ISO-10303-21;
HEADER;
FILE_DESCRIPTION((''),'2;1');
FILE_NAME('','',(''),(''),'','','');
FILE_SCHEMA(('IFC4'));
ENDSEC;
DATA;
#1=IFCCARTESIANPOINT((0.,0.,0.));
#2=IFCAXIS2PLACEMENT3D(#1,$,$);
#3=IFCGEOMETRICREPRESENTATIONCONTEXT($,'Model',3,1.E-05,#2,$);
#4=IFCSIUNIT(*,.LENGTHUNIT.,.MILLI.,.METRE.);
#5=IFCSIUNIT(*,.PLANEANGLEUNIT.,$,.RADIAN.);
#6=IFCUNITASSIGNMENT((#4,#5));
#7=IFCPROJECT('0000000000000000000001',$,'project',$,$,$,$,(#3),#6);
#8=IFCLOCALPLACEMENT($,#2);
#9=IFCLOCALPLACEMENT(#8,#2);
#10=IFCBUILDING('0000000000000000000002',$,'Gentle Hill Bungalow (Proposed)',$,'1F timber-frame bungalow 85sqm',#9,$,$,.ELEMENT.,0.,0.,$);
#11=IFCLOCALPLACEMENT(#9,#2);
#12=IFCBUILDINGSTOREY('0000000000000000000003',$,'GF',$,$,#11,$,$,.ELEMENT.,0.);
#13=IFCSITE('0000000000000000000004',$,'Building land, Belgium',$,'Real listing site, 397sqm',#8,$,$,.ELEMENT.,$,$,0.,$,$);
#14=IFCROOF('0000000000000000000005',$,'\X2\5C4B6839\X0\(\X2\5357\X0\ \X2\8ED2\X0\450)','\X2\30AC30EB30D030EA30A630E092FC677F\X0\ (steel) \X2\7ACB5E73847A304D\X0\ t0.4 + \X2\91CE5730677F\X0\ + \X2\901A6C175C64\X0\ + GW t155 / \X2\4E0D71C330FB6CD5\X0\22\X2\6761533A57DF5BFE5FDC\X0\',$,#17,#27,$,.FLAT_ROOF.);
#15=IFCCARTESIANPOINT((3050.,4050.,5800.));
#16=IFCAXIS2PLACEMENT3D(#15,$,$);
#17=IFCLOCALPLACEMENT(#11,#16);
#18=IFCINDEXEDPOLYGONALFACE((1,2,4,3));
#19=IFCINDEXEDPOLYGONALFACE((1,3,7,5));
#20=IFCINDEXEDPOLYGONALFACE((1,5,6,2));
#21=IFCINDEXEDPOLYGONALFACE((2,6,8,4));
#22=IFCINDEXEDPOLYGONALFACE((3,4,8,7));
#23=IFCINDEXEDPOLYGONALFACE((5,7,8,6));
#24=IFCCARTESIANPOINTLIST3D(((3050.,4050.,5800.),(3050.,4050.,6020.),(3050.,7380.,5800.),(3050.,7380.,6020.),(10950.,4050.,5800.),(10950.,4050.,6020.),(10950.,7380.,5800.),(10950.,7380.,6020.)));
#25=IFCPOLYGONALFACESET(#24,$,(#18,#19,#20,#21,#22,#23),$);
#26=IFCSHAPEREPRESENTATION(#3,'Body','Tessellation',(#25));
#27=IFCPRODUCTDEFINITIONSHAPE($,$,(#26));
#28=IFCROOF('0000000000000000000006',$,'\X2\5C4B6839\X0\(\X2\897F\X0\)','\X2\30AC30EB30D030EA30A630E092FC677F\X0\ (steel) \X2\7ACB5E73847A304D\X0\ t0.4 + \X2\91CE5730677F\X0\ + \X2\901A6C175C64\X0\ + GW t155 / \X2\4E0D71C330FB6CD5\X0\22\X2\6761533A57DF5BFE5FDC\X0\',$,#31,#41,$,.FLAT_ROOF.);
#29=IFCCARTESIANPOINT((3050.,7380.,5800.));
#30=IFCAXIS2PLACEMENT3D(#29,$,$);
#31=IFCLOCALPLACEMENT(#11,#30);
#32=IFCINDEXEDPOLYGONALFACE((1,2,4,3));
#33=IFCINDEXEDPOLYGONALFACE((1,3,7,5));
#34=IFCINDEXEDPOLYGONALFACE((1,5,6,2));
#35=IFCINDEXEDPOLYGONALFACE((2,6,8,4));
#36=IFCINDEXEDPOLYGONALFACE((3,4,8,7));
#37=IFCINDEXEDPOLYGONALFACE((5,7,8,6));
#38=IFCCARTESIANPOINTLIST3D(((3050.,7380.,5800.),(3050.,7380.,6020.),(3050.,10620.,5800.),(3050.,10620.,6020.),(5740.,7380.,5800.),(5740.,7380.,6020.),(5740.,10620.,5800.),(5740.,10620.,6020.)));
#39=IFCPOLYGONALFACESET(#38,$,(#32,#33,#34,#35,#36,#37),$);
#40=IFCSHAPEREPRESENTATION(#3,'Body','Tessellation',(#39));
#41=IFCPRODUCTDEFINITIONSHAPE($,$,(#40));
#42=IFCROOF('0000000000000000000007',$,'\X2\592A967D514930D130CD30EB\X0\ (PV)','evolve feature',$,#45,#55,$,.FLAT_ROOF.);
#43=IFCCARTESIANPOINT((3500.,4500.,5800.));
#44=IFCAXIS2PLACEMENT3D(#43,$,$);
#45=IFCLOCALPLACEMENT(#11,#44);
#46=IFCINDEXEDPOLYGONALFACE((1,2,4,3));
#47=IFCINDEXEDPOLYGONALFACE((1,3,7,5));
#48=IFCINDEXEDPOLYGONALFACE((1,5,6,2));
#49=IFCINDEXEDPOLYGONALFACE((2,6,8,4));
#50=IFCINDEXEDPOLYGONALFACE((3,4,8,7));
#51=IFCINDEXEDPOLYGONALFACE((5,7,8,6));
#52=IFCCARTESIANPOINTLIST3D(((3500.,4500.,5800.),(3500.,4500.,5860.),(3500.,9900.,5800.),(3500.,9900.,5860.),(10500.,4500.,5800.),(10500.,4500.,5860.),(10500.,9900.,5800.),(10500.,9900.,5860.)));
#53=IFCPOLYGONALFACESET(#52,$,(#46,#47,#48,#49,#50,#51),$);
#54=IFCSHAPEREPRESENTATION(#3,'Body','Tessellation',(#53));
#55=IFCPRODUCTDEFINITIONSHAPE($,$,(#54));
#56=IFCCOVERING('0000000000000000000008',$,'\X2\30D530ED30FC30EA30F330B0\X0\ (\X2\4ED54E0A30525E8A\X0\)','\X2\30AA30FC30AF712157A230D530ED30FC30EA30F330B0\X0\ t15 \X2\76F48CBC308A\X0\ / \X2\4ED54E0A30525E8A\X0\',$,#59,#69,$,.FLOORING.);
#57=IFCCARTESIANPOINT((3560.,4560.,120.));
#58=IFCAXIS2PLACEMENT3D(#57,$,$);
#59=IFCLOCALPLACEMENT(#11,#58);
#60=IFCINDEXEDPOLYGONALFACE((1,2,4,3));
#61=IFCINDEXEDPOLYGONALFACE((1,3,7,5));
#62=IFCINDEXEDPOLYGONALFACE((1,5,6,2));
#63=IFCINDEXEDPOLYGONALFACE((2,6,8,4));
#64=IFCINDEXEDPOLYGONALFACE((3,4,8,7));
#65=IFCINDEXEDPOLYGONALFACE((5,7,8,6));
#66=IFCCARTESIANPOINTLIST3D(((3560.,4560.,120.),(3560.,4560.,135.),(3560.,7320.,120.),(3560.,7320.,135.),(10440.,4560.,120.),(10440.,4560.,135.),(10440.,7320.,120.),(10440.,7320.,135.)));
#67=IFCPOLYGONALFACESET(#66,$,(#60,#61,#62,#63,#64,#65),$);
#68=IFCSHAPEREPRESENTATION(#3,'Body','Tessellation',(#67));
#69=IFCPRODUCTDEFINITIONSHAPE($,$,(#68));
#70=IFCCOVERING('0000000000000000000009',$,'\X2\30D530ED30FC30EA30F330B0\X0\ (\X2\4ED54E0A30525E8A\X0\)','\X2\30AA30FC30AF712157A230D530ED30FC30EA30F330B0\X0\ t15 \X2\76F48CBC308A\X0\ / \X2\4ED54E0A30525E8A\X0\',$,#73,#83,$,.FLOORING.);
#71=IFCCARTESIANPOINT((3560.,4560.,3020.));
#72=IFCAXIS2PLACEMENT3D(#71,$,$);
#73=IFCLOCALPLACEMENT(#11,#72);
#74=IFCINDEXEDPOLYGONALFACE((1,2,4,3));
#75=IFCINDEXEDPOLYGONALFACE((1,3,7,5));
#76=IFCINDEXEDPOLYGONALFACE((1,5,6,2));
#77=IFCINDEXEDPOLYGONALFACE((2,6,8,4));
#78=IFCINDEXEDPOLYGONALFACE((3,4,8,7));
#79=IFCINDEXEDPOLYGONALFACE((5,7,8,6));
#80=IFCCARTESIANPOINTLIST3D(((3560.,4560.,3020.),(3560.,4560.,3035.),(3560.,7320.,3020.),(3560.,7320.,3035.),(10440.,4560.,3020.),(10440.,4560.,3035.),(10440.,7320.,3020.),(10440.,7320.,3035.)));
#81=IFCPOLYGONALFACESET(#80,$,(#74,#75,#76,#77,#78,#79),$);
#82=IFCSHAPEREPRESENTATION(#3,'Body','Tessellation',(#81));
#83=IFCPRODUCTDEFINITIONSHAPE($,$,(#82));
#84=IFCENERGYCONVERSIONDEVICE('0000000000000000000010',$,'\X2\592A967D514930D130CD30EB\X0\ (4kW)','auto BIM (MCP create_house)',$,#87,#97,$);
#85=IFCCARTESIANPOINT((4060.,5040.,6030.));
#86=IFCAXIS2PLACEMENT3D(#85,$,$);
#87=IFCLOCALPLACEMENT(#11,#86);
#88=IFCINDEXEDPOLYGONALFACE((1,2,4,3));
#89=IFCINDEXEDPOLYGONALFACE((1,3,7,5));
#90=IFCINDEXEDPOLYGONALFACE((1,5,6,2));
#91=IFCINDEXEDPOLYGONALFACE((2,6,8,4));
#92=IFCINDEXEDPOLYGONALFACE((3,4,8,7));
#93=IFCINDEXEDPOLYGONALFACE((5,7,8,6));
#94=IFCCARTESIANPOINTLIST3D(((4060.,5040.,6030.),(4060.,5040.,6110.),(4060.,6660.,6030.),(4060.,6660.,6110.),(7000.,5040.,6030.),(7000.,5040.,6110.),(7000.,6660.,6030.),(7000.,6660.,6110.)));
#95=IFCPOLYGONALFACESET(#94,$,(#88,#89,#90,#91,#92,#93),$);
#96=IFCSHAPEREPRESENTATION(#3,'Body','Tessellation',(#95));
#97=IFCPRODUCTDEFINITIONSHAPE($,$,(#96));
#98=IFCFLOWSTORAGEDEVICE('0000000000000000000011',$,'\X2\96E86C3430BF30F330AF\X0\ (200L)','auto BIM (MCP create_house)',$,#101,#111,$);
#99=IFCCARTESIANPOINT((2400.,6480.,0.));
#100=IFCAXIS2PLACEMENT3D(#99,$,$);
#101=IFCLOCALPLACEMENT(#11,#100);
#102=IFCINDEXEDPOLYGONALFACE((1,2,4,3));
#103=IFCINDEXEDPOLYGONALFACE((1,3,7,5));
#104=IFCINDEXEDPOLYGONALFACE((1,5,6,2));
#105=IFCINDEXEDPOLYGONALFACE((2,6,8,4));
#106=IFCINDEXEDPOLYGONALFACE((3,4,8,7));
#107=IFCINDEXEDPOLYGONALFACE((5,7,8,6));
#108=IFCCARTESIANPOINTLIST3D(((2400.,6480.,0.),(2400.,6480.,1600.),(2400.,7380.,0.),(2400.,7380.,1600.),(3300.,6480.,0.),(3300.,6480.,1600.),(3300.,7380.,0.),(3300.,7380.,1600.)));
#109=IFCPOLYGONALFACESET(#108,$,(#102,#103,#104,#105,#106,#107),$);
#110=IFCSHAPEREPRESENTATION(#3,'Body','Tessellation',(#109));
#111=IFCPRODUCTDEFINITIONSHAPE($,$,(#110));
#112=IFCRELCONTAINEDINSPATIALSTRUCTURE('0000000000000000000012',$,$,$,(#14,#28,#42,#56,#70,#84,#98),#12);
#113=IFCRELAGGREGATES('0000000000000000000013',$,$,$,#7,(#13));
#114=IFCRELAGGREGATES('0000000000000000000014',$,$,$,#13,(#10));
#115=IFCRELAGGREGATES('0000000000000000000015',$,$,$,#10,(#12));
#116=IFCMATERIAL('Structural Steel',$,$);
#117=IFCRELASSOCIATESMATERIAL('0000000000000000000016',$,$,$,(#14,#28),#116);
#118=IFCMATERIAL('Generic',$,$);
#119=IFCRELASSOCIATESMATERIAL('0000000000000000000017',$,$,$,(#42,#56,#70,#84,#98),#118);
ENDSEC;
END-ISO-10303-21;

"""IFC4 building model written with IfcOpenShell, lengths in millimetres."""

from ifc_helpers import new_model, si_unit, frame, frame_2d, origin, place, context, project, spatial, rectangle, extrude, material, element, save


model = new_model("IFC4")

# Units and contexts
model_context = context("Model", 3, precision=1e-05, world=origin())
ifc_project = project(units=[si_unit("LENGTHUNIT", "METRE", prefix="MILLI"), si_unit("PLANEANGLEUNIT", "RADIAN")], contexts=[model_context])

# Site, building, storey
site_placement = place(None, origin())
site = spatial("IfcSite", under=ifc_project, at=site_placement, Name="Building land, Belgium", ObjectType="Real listing site, 397sqm", CompositionType="ELEMENT", RefElevation=0.0)
building_placement = place(site_placement, origin())
building = spatial("IfcBuilding", under=site, at=building_placement, Name="Gentle Hill Bungalow (Proposed)", ObjectType="1F timber-frame bungalow 85sqm", CompositionType="ELEMENT", ElevationOfRefHeight=0.0, ElevationOfTerrain=0.0)
storey_placement = place(building_placement, origin())
storey = spatial("IfcBuildingStorey", under=building, at=storey_placement, Name="GF", CompositionType="ELEMENT", Elevation=0.0)

# Shared definitions
ifc_material_1 = material(Name="Generic")

# Roofs
ifc_material_2 = material(Name="Structural Steel")
roof_1_placement = place(storey_placement, frame((3050.0, 4050.0, 5800.0)))
element("IfcRoof", 1, at=roof_1_placement, inside=storey, material=ifc_material_2, Name="屋根(南 軒450)", Description="ガルバリウム鋼板 (steel) 立平葺き t0.4 + 野地板 + 通気層 + GW t155 / 不燃・法22条区域対応", PredefinedType="FLAT_ROOF", context=model_context, shape_type="SweptSolid", body=[
    extrude(rectangle(XDim=7900.0, YDim=3330.0, at=frame_2d((3950.0, 1665.0))), frame((3050.0, 4050.0, 5800.0)), (0.0, 0.0, 1.0), 220.0),
])
roof_2_placement = place(storey_placement, frame((3050.0, 7380.0, 5800.0)))
element("IfcRoof", 2, at=roof_2_placement, inside=storey, material=ifc_material_2, Name="屋根(西)", Description="ガルバリウム鋼板 (steel) 立平葺き t0.4 + 野地板 + 通気層 + GW t155 / 不燃・法22条区域対応", PredefinedType="FLAT_ROOF", context=model_context, shape_type="SweptSolid", body=[
    extrude(rectangle(XDim=2690.0, YDim=3240.0, at=frame_2d((1345.0, 1620.0))), frame((3050.0, 7380.0, 5800.0)), (0.0, 0.0, 1.0), 220.0),
])
roof_3_placement = place(storey_placement, frame((3500.0, 4500.0, 5800.0)))
element("IfcRoof", 3, at=roof_3_placement, inside=storey, material=ifc_material_1, Name="太陽光パネル (PV)", Description="evolve feature", PredefinedType="FLAT_ROOF", context=model_context, shape_type="SweptSolid", body=[
    extrude(rectangle(XDim=7000.0, YDim=5400.0, at=frame_2d((3500.0, 2700.0))), frame((3500.0, 4500.0, 5800.0)), (0.0, 0.0, 1.0), 60.0),
])

# Coverings
covering_1_placement = place(storey_placement, frame((3560.0, 4560.0, 120.0)))
element("IfcCovering", 4, at=covering_1_placement, inside=storey, material=ifc_material_1, Name="フローリング (仕上げ床)", Description="オーク無垢フローリング t15 直貼り / 仕上げ床", PredefinedType="FLOORING", context=model_context, shape_type="SweptSolid", body=[
    extrude(rectangle(XDim=6880.0, YDim=2760.0, at=frame_2d((3440.0, 1380.0))), frame((3560.0, 4560.0, 120.0)), (0.0, 0.0, 1.0), 15.0),
])
covering_2_placement = place(storey_placement, frame((3560.0, 4560.0, 3020.0)))
element("IfcCovering", 5, at=covering_2_placement, inside=storey, material=ifc_material_1, Name="フローリング (仕上げ床)", Description="オーク無垢フローリング t15 直貼り / 仕上げ床", PredefinedType="FLOORING", context=model_context, shape_type="SweptSolid", body=[
    extrude(rectangle(XDim=6880.0, YDim=2760.0, at=frame_2d((3440.0, 1380.0))), frame((3560.0, 4560.0, 3020.0)), (0.0, 0.0, 1.0), 15.0),
])

# Energy conversion device
energy_conversion_device_placement = place(storey_placement, frame((4060.0, 5040.0, 6030.0)))
element("IfcEnergyConversionDevice", 6, at=energy_conversion_device_placement, inside=storey, material=ifc_material_1, Name="太陽光パネル (4kW)", Description="auto BIM (MCP create_house)", context=model_context, shape_type="SweptSolid", body=[
    extrude(rectangle(XDim=2940.0, YDim=1620.0, at=frame_2d((1470.0, 810.0))), frame((4060.0, 5040.0, 6030.0)), (0.0, 0.0, 1.0), 80.0),
])

# Flow storage device
flow_storage_device_placement = place(storey_placement, frame((2400.0, 6480.0, 0.0)))
element("IfcFlowStorageDevice", 7, at=flow_storage_device_placement, inside=storey, material=ifc_material_1, Name="雨水タンク (200L)", Description="auto BIM (MCP create_house)", context=model_context, shape_type="SweptSolid", body=[
    extrude(rectangle(XDim=900.0, YDim=900.0, at=frame_2d((450.0, 450.0))), frame((2400.0, 6480.0, 0.0)), (0.0, 0.0, 1.0), 1600.0),
])

save(model, "model.ifc")
